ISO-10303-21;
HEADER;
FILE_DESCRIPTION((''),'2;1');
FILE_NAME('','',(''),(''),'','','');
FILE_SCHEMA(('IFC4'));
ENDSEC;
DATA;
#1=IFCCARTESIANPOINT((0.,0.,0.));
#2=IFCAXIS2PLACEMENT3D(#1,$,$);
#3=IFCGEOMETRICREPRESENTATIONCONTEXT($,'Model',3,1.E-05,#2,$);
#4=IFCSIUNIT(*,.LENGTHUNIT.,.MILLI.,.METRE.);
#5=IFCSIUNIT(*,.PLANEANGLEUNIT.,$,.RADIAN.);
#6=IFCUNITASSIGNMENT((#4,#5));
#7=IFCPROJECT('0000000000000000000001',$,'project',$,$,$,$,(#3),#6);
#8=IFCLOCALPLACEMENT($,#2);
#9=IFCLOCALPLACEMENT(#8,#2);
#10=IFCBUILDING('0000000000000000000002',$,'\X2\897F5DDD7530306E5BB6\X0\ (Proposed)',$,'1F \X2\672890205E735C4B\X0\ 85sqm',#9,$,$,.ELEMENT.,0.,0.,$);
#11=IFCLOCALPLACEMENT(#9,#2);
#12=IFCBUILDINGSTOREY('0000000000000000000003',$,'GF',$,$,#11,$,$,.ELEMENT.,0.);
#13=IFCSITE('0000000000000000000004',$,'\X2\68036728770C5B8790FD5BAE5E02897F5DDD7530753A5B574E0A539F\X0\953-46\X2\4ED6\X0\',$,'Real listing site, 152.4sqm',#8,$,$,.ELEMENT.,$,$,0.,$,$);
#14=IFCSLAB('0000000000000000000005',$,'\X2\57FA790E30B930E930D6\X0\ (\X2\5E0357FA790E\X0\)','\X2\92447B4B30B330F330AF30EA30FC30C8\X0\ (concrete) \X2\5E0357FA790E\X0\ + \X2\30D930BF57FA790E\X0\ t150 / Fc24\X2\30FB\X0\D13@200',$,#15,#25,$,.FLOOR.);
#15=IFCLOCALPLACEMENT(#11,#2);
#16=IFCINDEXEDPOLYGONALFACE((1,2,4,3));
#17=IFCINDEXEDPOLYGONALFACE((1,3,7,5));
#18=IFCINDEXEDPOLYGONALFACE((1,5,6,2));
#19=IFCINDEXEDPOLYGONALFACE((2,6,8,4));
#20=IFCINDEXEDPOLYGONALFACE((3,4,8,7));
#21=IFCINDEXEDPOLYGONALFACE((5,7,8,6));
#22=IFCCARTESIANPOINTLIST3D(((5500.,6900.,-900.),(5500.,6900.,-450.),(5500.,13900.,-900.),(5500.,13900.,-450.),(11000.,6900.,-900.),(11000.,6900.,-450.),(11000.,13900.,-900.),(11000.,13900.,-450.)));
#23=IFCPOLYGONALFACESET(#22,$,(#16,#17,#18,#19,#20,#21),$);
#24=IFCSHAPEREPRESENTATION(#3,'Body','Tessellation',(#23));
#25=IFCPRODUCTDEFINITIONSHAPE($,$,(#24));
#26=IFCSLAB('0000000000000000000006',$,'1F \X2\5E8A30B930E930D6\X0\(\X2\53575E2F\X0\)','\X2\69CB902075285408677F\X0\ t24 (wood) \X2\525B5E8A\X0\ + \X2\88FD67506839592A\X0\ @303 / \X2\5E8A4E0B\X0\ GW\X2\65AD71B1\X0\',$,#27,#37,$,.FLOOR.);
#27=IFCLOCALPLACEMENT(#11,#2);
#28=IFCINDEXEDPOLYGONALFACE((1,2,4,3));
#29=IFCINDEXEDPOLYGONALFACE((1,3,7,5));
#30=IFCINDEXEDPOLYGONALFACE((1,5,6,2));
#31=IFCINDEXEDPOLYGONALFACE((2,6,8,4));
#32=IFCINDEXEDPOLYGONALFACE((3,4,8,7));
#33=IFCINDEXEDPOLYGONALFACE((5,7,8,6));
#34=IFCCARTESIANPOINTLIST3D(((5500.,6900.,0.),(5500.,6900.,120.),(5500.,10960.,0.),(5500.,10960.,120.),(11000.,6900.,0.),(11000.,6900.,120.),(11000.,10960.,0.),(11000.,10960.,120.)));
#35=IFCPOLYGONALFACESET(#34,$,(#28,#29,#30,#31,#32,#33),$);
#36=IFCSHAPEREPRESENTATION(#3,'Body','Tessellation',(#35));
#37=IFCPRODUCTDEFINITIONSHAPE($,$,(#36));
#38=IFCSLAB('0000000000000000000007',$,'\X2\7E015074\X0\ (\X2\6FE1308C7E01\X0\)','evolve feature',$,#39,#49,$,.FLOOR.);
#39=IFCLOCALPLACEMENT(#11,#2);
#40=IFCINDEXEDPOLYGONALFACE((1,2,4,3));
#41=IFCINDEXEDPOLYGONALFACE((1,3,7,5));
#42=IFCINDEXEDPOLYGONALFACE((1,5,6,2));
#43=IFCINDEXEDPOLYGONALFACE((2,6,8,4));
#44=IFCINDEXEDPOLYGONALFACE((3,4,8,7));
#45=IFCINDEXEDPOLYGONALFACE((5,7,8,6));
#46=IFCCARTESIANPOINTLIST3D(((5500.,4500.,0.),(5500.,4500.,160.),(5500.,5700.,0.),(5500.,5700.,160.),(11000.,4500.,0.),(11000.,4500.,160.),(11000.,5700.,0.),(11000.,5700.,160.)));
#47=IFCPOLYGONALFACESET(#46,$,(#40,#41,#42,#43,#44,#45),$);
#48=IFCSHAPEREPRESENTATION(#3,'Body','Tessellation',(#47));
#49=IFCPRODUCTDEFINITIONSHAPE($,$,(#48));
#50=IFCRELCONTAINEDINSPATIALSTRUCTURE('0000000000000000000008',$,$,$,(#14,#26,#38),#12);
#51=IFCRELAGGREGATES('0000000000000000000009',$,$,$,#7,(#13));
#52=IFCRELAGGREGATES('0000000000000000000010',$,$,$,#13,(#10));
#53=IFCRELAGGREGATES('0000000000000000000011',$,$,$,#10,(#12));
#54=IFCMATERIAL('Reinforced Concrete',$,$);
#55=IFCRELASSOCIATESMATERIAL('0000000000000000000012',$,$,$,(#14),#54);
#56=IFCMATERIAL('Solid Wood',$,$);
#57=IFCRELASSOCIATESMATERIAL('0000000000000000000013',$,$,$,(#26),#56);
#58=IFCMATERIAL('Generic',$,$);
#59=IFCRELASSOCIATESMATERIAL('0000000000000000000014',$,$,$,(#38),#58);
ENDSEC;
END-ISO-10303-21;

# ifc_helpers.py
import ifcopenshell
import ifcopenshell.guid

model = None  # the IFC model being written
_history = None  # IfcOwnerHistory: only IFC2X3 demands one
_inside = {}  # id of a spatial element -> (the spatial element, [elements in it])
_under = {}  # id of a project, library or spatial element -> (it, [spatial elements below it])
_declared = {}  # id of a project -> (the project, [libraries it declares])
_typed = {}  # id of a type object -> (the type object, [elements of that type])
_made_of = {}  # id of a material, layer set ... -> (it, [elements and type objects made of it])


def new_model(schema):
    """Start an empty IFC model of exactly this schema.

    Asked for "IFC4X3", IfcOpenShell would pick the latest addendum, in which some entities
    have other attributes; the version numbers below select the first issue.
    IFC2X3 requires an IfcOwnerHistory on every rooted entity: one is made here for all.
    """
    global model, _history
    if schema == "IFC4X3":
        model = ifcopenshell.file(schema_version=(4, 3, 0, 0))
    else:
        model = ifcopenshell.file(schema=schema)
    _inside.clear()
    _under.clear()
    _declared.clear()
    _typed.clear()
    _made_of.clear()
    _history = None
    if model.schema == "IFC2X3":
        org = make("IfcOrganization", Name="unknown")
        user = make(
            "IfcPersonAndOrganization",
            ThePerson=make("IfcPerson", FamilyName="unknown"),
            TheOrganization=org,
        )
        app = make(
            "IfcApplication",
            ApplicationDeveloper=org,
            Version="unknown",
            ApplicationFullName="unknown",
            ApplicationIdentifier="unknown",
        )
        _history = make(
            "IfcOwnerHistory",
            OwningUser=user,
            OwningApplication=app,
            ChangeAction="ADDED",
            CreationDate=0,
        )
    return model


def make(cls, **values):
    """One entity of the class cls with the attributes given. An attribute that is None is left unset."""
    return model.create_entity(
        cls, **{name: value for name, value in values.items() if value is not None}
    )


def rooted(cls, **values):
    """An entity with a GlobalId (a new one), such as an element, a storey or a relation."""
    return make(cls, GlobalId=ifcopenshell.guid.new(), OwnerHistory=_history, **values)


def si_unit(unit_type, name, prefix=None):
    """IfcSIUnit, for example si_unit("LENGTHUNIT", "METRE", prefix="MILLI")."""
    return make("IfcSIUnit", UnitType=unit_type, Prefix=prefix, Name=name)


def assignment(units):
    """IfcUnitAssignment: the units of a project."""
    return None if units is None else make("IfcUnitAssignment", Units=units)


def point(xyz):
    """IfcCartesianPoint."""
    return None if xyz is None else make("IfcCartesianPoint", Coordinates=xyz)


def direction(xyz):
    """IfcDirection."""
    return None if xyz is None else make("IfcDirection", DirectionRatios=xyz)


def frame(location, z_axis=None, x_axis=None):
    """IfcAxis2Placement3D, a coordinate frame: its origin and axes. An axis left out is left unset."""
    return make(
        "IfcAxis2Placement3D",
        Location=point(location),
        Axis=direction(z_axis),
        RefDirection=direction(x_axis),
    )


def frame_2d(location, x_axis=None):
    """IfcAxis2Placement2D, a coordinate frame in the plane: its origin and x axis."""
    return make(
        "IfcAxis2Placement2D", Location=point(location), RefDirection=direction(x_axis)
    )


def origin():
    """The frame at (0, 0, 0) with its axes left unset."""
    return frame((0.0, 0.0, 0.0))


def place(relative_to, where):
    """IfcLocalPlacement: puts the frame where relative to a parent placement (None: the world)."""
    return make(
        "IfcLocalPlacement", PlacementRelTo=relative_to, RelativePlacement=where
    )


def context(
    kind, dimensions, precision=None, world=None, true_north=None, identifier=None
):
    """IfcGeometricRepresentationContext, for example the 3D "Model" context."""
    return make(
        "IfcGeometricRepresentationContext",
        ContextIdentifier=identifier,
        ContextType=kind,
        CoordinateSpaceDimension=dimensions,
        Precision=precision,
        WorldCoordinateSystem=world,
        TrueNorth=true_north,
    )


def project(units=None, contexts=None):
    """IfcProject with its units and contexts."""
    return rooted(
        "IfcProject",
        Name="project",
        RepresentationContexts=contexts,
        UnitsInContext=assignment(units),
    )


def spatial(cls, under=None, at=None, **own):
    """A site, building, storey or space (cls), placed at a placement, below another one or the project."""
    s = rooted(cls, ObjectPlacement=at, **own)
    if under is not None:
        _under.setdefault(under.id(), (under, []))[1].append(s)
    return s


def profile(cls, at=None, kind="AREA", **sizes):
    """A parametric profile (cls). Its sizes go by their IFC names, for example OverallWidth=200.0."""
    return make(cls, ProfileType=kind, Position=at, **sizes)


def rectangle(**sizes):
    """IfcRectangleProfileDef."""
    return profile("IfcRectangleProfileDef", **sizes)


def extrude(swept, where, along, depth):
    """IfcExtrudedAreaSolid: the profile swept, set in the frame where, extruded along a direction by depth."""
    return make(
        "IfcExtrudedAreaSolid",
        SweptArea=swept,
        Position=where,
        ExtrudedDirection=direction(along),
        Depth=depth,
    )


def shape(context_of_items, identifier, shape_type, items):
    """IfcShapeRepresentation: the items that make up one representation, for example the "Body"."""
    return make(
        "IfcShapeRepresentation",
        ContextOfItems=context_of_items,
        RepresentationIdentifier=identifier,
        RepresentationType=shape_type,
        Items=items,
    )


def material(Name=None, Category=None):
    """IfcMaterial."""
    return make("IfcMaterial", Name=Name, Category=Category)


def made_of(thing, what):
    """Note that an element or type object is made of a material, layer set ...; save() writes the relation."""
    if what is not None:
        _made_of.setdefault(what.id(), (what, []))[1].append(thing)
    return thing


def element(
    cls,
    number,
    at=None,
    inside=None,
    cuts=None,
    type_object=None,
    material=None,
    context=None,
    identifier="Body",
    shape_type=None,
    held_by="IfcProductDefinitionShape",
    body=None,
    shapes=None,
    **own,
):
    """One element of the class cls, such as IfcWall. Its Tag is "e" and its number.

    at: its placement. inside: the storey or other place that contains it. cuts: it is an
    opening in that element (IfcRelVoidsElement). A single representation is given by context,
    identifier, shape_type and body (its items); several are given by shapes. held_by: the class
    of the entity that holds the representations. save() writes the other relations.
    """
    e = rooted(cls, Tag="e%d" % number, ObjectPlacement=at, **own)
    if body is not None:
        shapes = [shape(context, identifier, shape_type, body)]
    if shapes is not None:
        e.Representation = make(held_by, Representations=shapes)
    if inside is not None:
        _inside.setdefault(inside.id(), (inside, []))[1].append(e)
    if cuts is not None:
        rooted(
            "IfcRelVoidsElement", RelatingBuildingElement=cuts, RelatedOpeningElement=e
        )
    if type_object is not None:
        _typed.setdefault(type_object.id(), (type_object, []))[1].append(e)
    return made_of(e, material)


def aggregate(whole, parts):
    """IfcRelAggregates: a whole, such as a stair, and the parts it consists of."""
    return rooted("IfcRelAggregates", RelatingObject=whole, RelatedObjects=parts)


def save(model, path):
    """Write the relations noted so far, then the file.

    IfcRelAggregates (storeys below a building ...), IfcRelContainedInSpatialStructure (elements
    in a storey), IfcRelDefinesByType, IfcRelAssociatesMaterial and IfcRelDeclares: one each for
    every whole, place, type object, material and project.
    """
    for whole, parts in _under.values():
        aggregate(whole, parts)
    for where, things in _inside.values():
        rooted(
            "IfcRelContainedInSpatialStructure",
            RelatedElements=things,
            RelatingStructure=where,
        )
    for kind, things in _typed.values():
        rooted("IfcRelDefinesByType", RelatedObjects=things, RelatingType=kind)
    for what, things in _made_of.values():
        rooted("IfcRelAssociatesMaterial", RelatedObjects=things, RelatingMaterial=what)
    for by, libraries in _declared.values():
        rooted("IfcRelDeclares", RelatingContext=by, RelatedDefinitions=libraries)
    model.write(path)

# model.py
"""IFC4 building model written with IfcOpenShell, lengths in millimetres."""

from ifc_helpers import new_model, si_unit, frame, frame_2d, origin, place, context, project, spatial, rectangle, extrude, material, element, save


model = new_model("IFC4")

# Units and contexts
model_context = context("Model", 3, precision=1e-05, world=origin())
ifc_project = project(units=[si_unit("LENGTHUNIT", "METRE", prefix="MILLI"), si_unit("PLANEANGLEUNIT", "RADIAN")], contexts=[model_context])

# Site, building, storey
site_placement = place(None, origin())
site = spatial("IfcSite", under=ifc_project, at=site_placement, Name="栃木県宇都宮市西川田町字上原953-46他", ObjectType="Real listing site, 152.4sqm", CompositionType="ELEMENT", RefElevation=0.0)
building_placement = place(site_placement, origin())
building = spatial("IfcBuilding", under=site, at=building_placement, Name="西川田の家 (Proposed)", ObjectType="1F 木造平屋 85sqm", CompositionType="ELEMENT", ElevationOfRefHeight=0.0, ElevationOfTerrain=0.0)
storey_placement = place(building_placement, origin())
storey = spatial("IfcBuildingStorey", under=building, at=storey_placement, Name="GF", CompositionType="ELEMENT", Elevation=0.0)

# Slabs
ifc_material_1 = material(Name="Reinforced Concrete")
slab_1_placement = place(storey_placement, frame((2750.0, 3450.0, -450.0)))
element("IfcSlab", 1, at=slab_1_placement, inside=storey, material=ifc_material_1, Name="基礎スラブ (布基礎)", Description="鉄筋コンクリート (concrete) 布基礎 + ベタ基礎 t150 / Fc24・D13@200", PredefinedType="FLOOR", context=model_context, shape_type="SweptSolid", body=[
    extrude(rectangle(XDim=5500.0, YDim=7000.0, at=frame_2d((2750.0, 3500.0))), frame((2750.0, 3450.0, -450.0)), (0.0, 0.0, 1.0), 450.0),
])
ifc_material_2 = material(Name="Solid Wood")
slab_2_placement = place(storey_placement, frame((2750.0, 3450.0, 0.0)))
element("IfcSlab", 2, at=slab_2_placement, inside=storey, material=ifc_material_2, Name="1F 床スラブ(南帯)", Description="構造用合板 t24 (wood) 剛床 + 製材根太 @303 / 床下 GW断熱", PredefinedType="FLOOR", context=model_context, shape_type="SweptSolid", body=[
    extrude(rectangle(XDim=5500.0, YDim=4060.0, at=frame_2d((2750.0, 2030.0))), frame((2750.0, 3450.0, 0.0)), (0.0, 0.0, 1.0), 120.0),
])
ifc_material_3 = material(Name="Generic")
slab_3_placement = place(storey_placement, frame((2750.0, 2250.0, 0.0)))
element("IfcSlab", 3, at=slab_3_placement, inside=storey, material=ifc_material_3, Name="縁側 (濡れ縁)", Description="evolve feature", PredefinedType="FLOOR", context=model_context, shape_type="SweptSolid", body=[
    extrude(rectangle(XDim=5500.0, YDim=1200.0, at=frame_2d((2750.0, 600.0))), frame((2750.0, 2250.0, 0.0)), (0.0, 0.0, 1.0), 160.0),
])

save(model, "model.ifc")
